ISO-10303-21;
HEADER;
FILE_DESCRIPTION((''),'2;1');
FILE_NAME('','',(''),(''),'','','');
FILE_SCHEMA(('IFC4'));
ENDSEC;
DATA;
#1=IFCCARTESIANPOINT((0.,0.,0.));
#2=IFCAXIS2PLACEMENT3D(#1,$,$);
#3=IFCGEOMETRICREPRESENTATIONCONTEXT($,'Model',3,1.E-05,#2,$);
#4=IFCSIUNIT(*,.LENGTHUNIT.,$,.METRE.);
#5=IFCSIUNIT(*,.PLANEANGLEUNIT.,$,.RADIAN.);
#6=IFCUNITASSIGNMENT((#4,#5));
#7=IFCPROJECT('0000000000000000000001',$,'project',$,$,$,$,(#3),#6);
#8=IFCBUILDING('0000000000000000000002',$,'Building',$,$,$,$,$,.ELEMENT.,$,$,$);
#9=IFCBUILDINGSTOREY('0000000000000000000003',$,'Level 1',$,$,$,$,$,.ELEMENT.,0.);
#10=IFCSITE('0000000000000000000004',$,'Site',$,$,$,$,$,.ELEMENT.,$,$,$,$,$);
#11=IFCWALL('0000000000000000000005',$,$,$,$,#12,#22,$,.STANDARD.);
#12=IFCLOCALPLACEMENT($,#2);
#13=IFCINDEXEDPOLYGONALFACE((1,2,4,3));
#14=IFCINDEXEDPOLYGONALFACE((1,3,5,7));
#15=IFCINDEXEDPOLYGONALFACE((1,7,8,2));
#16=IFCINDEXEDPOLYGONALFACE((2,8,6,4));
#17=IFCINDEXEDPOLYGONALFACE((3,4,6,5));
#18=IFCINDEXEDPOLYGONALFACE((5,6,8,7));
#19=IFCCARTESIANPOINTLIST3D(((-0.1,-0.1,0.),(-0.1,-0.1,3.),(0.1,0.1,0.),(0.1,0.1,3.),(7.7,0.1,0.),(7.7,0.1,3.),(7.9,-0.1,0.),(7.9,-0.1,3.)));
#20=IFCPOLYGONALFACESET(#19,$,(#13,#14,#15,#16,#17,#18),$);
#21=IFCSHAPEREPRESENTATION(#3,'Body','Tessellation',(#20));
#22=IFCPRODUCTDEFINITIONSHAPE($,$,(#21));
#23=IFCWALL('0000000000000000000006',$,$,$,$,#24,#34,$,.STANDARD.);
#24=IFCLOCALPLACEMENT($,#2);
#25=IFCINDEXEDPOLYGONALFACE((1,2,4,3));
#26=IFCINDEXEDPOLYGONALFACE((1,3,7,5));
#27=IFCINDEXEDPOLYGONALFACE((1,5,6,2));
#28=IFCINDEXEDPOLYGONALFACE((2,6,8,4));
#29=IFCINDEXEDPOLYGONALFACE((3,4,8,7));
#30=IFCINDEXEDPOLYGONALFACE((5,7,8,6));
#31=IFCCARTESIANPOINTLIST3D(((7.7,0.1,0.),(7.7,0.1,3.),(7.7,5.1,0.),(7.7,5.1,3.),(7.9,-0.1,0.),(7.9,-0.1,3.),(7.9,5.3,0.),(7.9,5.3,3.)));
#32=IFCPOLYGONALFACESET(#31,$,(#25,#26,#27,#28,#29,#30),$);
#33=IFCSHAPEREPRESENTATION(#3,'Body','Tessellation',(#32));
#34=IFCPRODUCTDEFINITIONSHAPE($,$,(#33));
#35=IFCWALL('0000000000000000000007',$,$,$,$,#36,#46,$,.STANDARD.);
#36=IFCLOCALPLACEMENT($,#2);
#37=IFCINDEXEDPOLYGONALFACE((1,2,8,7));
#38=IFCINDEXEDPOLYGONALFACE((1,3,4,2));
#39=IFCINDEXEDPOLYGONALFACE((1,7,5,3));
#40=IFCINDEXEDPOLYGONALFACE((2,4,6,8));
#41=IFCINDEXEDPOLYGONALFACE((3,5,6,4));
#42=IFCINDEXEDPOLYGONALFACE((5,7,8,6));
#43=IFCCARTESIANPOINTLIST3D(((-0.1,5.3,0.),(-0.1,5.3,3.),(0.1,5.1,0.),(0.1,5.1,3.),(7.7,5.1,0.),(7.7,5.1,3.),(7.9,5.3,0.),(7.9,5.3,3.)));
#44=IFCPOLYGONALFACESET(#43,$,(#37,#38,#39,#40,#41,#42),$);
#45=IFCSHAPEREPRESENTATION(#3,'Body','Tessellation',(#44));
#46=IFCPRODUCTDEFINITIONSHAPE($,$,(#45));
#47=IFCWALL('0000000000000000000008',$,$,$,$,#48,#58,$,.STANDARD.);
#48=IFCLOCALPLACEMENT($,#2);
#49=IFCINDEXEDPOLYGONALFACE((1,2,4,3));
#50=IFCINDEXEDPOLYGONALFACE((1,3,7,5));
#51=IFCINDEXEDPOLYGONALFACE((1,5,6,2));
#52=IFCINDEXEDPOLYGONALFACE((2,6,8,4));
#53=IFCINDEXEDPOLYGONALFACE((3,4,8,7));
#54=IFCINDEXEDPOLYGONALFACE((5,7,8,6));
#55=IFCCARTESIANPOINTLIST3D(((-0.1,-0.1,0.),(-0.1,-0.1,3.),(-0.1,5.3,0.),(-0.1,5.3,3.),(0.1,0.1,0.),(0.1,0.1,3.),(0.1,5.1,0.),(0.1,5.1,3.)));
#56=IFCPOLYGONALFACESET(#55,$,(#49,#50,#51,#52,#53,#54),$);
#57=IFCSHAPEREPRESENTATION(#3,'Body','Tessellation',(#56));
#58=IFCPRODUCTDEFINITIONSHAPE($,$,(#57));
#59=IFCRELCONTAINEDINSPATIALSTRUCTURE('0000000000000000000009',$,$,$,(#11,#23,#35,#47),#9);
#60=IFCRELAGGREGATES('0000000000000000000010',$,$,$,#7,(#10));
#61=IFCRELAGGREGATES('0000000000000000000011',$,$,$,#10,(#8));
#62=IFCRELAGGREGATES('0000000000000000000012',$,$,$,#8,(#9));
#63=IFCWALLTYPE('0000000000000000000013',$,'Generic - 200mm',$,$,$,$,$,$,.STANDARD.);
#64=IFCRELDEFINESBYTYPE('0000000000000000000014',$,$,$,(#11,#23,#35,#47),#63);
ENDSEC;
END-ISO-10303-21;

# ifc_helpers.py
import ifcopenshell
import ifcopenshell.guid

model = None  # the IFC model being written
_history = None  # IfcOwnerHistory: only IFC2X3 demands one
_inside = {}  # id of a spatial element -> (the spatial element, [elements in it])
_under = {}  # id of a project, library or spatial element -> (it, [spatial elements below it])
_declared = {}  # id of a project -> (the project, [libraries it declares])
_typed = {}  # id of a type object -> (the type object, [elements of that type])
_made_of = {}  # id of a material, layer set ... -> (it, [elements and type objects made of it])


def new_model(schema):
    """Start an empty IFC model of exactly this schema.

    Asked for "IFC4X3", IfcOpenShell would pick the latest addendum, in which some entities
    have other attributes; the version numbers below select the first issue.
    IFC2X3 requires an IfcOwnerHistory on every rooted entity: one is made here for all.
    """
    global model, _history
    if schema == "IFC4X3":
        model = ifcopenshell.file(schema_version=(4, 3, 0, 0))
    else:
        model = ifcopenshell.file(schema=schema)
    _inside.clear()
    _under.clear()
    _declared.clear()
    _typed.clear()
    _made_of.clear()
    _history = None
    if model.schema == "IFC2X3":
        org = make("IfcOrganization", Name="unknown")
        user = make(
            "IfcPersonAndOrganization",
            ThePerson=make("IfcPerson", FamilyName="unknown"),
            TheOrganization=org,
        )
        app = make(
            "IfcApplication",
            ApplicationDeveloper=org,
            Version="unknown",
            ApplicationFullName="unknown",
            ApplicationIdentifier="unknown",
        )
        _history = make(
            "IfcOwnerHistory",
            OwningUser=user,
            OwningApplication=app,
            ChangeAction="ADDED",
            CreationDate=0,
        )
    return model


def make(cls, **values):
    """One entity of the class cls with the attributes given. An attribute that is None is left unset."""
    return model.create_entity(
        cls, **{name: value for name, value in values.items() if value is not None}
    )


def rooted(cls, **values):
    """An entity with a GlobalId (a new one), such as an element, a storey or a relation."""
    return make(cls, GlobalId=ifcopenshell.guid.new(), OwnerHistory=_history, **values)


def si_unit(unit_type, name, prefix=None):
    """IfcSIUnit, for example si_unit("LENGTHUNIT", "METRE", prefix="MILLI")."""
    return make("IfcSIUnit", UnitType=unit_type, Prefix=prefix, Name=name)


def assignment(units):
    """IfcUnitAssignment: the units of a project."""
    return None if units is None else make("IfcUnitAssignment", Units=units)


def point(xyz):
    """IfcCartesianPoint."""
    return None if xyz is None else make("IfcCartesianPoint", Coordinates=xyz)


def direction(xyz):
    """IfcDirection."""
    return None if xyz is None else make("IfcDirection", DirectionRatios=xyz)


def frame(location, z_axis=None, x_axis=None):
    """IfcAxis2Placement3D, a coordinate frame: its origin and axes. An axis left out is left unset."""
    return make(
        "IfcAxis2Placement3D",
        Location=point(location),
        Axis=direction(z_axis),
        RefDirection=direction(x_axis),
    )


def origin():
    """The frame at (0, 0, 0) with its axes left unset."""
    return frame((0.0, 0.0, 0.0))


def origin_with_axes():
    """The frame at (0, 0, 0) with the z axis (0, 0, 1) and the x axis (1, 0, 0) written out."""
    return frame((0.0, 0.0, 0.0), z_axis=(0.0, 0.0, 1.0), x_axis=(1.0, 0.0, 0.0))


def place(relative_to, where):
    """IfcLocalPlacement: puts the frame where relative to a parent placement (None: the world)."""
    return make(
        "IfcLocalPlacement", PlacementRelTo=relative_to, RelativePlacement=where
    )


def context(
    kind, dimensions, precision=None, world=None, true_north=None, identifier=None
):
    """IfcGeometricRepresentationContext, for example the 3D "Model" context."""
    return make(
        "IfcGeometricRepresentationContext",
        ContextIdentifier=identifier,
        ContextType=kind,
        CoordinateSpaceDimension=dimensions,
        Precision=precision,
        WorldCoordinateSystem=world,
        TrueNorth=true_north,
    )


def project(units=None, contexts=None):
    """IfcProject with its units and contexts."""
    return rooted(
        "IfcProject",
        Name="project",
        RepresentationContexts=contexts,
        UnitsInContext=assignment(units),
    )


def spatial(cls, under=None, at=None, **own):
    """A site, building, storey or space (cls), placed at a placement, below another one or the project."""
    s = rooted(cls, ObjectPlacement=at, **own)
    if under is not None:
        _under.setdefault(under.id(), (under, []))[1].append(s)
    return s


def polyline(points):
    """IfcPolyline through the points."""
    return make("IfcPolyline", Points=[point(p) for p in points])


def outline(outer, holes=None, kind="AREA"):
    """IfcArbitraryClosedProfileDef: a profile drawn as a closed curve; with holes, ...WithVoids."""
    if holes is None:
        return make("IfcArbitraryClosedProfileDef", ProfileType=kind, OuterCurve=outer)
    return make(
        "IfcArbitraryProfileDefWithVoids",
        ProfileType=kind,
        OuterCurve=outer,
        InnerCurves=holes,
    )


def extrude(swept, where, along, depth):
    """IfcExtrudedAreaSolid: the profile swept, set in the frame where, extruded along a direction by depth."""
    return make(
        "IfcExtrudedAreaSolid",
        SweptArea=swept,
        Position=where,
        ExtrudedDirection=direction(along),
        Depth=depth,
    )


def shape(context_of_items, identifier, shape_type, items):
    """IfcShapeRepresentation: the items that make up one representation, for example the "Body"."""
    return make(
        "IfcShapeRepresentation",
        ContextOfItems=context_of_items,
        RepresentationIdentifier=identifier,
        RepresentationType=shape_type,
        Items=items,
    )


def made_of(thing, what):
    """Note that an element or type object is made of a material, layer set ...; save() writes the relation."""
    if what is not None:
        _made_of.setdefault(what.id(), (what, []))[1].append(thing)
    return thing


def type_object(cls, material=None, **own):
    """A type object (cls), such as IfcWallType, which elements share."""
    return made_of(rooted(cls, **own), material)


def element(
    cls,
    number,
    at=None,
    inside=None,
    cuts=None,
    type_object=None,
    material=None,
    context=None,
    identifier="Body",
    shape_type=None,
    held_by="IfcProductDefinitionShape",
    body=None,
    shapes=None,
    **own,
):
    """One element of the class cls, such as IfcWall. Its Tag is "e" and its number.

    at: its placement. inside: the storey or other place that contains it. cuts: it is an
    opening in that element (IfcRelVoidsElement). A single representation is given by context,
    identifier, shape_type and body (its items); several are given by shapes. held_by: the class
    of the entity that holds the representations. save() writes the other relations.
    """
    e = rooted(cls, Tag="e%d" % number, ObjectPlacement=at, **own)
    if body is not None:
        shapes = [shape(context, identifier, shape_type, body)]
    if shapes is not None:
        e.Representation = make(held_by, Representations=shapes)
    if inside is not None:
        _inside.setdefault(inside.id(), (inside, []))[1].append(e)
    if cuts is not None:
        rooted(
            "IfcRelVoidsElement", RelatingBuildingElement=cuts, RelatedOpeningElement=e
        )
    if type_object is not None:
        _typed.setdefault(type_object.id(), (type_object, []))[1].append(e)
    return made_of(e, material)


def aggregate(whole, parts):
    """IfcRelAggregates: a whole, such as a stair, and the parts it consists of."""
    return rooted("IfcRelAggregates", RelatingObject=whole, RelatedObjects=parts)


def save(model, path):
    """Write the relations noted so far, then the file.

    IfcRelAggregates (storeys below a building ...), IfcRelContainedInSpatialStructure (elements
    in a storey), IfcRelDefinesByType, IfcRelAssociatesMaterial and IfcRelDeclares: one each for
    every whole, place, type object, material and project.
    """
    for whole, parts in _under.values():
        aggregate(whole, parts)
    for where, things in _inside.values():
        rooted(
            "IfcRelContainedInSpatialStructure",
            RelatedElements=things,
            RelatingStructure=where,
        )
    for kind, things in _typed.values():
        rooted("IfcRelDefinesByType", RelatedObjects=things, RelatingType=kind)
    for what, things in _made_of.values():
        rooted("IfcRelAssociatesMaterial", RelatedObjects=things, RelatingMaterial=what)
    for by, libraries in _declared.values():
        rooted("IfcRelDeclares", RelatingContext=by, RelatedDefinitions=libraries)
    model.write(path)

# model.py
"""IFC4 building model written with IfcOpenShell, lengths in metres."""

from ifc_helpers import new_model, si_unit, frame, origin, origin_with_axes, place, context, project, spatial, polyline, outline, extrude, type_object, element, save


model = new_model("IFC4")

# Units and contexts
model_context = context("Model", 3, precision=1e-05, world=origin())
ifc_project = project(units=[si_unit("LENGTHUNIT", "METRE"), si_unit("PLANEANGLEUNIT", "RADIAN")], contexts=[model_context])

# Site, building, storey
site = spatial("IfcSite", under=ifc_project, Name="Site", CompositionType="ELEMENT")
building = spatial("IfcBuilding", under=site, Name="Building", CompositionType="ELEMENT")
storey = spatial("IfcBuildingStorey", under=building, Name="Level 1", CompositionType="ELEMENT", Elevation=0.0)

# Walls
wall_type = type_object("IfcWallType", Name="Generic - 200mm", PredefinedType="STANDARD")
wall_1_placement = place(None, origin_with_axes())
element("IfcWall", 1, at=wall_1_placement, inside=storey, type_object=wall_type, PredefinedType="STANDARD", context=model_context, shape_type="SweptSolid", body=[
    extrude(outline(polyline([(-0.1, -0.1), (7.9, -0.1), (7.7, 0.1), (0.1, 0.1), (-0.1, -0.1)])), origin(), (0.0, 0.0, 1.0), 3.0),
])
wall_2_placement = place(None, frame((7.8, 0.0, 0.0), z_axis=(0.0, 0.0, 1.0), x_axis=(0.0, 1.0, 0.0)))
element("IfcWall", 2, at=wall_2_placement, inside=storey, type_object=wall_type, PredefinedType="STANDARD", context=model_context, shape_type="SweptSolid", body=[
    extrude(outline(polyline([(-0.1, -0.1), (5.3, -0.1), (5.1, 0.1), (0.1, 0.1), (-0.1, -0.1)])), origin(), (0.0, 0.0, 1.0), 3.0),
])
wall_3_placement = place(None, frame((7.8, 5.2, 0.0), z_axis=(0.0, 0.0, 1.0), x_axis=(-1.0, 0.0, 0.0)))
element("IfcWall", 3, at=wall_3_placement, inside=storey, type_object=wall_type, PredefinedType="STANDARD", context=model_context, shape_type="SweptSolid", body=[
    extrude(outline(polyline([(-0.1, -0.1), (7.9, -0.1), (7.7, 0.1), (0.1, 0.1), (-0.1, -0.1)])), origin(), (0.0, 0.0, 1.0), 3.0),
])
wall_4_placement = place(None, frame((0.0, 5.2, 0.0), z_axis=(0.0, 0.0, 1.0), x_axis=(0.0, -1.0, 0.0)))
element("IfcWall", 4, at=wall_4_placement, inside=storey, type_object=wall_type, PredefinedType="STANDARD", context=model_context, shape_type="SweptSolid", body=[
    extrude(outline(polyline([(-0.1, -0.1), (5.3, -0.1), (5.1, 0.1), (0.1, 0.1), (-0.1, -0.1)])), origin(), (0.0, 0.0, 1.0), 3.0),
])

save(model, "model.ifc")
